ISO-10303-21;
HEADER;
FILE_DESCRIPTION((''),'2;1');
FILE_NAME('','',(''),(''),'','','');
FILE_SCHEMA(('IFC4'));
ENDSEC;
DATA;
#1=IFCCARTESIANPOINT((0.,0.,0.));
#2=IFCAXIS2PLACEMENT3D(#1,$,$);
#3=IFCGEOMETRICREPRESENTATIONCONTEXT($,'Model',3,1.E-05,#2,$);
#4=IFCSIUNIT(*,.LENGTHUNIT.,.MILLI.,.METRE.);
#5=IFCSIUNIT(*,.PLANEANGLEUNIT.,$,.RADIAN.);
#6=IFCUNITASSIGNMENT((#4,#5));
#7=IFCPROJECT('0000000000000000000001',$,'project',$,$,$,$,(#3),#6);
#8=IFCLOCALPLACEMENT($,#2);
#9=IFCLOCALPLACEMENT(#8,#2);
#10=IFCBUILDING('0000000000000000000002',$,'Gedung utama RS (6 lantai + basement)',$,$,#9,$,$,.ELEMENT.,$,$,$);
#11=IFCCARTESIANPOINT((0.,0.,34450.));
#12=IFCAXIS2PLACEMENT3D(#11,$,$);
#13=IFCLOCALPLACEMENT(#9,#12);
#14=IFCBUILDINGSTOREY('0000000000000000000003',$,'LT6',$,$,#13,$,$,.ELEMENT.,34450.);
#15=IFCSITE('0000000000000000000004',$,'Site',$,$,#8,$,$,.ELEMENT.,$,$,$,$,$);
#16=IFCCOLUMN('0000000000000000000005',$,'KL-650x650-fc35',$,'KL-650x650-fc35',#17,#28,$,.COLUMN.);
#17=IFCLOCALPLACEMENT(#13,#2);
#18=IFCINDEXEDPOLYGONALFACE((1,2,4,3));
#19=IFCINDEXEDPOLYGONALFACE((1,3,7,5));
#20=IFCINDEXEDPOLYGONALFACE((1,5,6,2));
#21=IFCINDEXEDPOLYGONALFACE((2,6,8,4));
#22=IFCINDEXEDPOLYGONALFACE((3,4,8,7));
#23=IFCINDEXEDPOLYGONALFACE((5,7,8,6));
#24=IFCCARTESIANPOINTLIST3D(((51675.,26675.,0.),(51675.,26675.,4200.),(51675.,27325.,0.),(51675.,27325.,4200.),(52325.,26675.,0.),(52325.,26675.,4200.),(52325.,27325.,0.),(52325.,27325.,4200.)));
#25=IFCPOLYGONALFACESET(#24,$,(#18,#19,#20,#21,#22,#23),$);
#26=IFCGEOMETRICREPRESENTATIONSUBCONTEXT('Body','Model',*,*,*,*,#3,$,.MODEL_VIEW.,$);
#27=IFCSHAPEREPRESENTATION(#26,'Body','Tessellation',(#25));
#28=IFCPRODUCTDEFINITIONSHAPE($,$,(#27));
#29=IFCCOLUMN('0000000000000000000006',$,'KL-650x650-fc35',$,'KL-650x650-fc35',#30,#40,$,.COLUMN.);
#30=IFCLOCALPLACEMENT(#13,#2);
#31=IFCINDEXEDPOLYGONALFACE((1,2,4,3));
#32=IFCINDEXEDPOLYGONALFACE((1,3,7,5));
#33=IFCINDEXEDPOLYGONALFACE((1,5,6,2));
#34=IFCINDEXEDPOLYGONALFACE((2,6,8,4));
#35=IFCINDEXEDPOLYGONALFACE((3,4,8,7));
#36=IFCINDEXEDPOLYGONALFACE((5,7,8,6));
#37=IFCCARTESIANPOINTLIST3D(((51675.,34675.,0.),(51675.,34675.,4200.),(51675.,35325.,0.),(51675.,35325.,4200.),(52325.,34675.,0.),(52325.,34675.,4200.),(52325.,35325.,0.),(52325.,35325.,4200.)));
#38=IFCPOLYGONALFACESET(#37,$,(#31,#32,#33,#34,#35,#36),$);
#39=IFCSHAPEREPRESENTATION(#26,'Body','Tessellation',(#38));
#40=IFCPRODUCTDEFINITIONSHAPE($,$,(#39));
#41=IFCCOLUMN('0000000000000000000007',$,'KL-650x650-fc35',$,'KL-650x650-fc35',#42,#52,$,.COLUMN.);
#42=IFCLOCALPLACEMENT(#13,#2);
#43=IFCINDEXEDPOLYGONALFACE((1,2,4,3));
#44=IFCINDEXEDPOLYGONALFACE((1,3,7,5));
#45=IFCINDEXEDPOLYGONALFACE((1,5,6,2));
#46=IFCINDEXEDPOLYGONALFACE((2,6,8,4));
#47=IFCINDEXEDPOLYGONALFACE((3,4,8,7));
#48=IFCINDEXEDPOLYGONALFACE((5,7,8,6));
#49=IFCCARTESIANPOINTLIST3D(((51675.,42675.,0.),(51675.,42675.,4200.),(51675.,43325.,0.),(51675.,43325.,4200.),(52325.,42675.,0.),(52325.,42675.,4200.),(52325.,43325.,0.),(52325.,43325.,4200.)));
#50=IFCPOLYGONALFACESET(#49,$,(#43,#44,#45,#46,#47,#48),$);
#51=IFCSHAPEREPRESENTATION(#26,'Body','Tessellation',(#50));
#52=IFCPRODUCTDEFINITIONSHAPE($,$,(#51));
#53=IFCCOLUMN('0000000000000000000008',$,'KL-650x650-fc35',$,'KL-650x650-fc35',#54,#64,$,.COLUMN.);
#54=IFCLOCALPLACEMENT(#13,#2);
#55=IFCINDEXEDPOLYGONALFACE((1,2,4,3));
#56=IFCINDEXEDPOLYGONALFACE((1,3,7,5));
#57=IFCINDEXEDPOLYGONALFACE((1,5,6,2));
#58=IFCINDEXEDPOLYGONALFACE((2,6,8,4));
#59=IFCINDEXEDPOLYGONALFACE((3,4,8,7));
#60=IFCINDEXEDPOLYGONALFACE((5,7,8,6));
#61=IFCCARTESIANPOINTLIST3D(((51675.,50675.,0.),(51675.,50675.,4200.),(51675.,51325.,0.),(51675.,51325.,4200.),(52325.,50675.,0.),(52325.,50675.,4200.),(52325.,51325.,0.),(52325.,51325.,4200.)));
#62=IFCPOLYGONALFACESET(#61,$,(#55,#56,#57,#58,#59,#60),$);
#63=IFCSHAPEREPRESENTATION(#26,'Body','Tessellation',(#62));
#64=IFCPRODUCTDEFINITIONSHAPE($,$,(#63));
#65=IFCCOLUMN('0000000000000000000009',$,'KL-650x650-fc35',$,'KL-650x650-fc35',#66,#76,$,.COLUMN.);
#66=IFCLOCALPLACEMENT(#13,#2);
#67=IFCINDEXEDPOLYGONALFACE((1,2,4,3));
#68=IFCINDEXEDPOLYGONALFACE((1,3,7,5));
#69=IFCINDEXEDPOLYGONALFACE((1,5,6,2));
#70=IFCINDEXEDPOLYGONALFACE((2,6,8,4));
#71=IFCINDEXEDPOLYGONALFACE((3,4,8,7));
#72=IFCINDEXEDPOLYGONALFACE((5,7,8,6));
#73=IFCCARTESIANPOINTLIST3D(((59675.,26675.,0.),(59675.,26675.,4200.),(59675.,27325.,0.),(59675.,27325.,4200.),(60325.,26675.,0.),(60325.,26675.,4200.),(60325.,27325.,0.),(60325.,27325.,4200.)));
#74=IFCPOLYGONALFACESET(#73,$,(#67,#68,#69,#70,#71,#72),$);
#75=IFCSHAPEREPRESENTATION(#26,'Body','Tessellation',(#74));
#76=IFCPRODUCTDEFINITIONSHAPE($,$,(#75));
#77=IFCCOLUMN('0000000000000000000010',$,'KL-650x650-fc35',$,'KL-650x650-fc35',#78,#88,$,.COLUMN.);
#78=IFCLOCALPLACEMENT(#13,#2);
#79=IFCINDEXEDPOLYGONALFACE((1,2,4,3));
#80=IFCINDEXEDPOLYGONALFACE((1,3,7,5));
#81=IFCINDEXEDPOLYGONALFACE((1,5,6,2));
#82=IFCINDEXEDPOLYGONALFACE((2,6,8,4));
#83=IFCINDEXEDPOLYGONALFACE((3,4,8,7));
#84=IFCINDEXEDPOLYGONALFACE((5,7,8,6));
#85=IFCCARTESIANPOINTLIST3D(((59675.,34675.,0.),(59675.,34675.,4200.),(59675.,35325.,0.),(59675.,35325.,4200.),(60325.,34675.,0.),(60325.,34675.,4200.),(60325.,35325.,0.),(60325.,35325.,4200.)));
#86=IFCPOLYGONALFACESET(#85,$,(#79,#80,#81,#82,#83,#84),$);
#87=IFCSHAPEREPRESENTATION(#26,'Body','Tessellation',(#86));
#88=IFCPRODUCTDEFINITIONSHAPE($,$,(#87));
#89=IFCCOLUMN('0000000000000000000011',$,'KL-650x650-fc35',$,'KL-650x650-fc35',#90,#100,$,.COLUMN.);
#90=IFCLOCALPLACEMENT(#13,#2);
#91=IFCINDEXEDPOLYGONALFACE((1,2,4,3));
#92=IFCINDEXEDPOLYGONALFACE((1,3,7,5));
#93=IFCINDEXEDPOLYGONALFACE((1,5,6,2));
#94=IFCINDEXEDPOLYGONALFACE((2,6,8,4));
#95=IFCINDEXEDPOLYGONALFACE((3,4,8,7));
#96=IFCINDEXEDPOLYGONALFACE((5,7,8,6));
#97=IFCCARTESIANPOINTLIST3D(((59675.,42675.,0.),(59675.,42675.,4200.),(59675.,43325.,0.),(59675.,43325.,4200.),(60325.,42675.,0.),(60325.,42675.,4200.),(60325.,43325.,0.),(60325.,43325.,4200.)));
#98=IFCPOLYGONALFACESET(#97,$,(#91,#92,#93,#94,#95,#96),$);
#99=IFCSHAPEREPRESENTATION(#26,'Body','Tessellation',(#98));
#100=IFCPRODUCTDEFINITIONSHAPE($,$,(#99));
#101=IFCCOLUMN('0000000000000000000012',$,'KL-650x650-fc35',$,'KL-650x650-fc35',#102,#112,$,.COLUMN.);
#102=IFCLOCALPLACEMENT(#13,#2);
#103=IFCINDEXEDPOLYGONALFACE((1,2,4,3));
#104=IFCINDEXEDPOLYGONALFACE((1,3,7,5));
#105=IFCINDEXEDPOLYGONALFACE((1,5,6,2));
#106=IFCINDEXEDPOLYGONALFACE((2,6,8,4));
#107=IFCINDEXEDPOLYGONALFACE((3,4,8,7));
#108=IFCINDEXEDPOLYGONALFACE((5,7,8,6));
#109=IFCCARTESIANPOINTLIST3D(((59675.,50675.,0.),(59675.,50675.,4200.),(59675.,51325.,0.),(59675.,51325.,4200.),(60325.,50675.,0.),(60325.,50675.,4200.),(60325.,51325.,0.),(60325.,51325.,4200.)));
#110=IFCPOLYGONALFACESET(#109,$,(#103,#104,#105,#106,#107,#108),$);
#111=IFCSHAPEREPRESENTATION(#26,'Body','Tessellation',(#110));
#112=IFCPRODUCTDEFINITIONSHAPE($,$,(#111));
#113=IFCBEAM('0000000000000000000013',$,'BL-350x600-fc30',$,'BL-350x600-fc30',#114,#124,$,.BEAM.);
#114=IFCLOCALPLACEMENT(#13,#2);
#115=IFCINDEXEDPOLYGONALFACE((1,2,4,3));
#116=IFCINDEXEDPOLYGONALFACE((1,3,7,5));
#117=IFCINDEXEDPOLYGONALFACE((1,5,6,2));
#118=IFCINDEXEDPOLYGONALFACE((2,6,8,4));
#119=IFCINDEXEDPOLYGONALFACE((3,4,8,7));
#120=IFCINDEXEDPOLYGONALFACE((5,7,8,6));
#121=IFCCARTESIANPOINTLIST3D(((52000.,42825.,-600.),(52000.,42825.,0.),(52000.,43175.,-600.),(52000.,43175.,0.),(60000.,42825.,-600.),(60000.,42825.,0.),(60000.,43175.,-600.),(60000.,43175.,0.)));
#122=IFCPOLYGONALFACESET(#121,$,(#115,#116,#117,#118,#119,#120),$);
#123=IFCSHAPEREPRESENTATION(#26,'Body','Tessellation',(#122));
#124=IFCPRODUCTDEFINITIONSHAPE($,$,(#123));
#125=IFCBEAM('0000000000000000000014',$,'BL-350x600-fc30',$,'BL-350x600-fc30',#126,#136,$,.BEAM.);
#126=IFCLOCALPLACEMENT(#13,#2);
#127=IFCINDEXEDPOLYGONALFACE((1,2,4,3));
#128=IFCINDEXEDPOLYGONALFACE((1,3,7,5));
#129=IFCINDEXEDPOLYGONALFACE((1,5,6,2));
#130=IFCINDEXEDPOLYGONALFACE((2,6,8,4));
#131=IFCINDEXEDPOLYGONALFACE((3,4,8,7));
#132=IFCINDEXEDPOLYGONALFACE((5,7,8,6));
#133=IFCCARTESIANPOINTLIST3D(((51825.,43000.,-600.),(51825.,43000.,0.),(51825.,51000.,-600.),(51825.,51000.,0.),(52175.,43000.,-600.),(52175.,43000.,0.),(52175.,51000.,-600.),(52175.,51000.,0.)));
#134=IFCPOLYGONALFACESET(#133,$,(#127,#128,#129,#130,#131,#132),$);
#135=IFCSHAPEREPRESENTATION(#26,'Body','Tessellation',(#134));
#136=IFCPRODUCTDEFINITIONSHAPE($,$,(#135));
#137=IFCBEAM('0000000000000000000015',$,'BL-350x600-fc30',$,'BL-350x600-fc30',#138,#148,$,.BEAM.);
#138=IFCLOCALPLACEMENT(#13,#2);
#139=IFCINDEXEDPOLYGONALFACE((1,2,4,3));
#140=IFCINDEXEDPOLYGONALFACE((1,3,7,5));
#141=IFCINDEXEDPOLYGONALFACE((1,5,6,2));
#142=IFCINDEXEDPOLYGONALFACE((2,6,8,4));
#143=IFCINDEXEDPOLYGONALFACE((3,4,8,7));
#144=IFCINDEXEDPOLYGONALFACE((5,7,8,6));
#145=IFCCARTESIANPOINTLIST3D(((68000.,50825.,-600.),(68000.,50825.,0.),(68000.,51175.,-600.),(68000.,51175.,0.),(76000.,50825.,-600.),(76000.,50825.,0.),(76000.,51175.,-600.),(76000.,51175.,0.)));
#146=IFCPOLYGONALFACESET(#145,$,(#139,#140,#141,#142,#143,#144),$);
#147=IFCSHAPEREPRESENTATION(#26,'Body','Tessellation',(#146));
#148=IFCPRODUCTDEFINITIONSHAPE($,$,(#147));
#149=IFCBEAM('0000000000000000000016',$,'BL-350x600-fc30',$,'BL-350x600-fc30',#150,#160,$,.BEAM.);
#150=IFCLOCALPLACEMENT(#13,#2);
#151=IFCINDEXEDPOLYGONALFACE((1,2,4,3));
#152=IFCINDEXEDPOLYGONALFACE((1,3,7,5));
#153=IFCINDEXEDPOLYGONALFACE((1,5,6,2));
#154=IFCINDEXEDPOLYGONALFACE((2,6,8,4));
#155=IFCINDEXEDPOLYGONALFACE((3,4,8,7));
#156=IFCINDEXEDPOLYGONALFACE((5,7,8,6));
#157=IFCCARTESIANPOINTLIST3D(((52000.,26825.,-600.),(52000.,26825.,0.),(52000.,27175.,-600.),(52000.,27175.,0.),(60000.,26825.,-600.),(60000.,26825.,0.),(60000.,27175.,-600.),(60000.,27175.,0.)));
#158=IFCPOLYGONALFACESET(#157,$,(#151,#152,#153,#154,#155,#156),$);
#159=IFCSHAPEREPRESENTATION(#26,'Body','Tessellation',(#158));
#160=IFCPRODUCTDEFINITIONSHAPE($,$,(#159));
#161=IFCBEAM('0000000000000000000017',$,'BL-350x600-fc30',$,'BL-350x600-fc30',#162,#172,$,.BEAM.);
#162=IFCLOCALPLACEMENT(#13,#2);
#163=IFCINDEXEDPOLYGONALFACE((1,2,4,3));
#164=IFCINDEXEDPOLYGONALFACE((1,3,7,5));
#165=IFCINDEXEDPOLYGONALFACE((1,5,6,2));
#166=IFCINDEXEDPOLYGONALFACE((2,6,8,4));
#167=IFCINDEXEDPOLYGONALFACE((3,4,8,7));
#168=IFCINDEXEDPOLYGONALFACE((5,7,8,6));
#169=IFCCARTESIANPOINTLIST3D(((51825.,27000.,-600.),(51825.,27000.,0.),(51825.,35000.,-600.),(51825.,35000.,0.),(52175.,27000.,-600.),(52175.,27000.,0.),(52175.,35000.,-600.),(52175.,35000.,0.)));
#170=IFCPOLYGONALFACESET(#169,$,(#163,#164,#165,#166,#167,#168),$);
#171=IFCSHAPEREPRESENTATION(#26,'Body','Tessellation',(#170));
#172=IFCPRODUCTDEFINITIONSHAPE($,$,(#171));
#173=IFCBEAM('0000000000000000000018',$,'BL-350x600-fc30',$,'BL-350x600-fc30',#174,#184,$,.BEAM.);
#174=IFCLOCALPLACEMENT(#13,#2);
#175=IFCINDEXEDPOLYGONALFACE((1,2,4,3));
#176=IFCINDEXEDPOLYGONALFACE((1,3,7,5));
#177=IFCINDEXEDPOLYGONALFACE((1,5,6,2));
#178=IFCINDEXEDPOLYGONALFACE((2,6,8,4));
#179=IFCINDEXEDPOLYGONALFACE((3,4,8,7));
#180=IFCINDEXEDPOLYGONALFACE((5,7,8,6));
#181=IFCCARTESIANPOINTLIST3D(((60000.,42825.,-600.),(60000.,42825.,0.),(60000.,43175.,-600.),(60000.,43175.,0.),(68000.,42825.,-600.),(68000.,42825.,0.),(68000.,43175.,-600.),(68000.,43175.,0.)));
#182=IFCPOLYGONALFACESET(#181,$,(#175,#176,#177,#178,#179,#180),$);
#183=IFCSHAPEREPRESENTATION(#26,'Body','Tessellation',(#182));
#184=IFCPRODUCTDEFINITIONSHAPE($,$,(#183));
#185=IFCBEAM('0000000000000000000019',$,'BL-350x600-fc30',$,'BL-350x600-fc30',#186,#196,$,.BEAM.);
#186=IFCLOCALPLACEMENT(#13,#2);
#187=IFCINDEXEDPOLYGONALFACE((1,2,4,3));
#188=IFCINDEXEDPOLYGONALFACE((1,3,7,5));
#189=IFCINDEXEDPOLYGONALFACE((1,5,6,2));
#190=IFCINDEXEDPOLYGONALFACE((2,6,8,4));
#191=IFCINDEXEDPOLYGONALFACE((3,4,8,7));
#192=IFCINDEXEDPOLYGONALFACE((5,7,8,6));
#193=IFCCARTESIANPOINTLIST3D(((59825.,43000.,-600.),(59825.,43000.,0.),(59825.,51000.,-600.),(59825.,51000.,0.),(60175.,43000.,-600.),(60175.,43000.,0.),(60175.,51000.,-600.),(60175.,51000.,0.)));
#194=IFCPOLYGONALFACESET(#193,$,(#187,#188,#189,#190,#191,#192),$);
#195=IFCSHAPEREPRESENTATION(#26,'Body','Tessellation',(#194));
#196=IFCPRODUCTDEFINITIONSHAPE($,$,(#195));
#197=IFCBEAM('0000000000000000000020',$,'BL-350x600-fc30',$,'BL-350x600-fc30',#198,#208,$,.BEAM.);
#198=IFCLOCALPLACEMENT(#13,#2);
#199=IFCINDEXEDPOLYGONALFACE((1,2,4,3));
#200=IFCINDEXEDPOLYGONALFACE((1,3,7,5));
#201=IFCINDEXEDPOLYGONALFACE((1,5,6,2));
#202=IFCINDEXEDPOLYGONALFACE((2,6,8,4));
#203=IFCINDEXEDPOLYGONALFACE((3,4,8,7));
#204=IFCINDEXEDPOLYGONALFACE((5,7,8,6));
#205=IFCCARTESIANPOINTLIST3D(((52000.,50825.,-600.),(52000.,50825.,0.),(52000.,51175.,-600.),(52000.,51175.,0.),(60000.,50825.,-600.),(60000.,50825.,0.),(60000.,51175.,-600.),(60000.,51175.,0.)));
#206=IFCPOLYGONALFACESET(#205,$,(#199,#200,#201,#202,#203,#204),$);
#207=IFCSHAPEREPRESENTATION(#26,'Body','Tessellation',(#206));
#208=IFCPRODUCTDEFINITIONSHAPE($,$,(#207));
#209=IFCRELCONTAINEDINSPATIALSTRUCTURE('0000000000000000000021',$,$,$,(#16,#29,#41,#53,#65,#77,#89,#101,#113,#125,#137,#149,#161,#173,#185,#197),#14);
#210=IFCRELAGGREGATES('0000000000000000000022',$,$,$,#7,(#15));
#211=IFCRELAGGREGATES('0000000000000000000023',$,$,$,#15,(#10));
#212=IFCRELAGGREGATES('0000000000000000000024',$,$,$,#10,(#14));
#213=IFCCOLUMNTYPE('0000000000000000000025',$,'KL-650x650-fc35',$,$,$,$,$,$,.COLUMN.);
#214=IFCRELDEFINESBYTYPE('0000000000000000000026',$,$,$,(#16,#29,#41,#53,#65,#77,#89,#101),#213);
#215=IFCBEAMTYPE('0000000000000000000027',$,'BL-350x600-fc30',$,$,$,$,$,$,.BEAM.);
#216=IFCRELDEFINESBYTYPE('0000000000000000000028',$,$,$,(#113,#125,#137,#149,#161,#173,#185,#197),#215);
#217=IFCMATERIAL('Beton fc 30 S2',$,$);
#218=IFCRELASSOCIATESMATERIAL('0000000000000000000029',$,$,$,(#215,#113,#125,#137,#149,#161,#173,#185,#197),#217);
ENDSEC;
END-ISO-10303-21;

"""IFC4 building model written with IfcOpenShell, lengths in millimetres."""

from ifc_helpers import new_model, si_unit, frame, origin, origin_2d, place, context, subcontext, project, spatial, rectangle, extrude, material, material_profile, profile_set, profile_usage, type_object, element, save


model = new_model("IFC4")

# Units and contexts
model_context = context("Model", 3, precision=1e-05, world=origin())
body_context = subcontext(model_context, "Body", "Model", "MODEL_VIEW")
ifc_project = project(units=[si_unit("LENGTHUNIT", "METRE", prefix="MILLI"), si_unit("PLANEANGLEUNIT", "RADIAN")], contexts=[model_context])

# Site, building, storey
site_placement = place(None, origin())
site = spatial("IfcSite", under=ifc_project, at=site_placement, Name="Site", CompositionType="ELEMENT")
building_placement = place(site_placement, origin())
building = spatial("IfcBuilding", under=site, at=building_placement, Name="Gedung utama RS (6 lantai + basement)", CompositionType="ELEMENT")
storey_placement = place(building_placement, frame((0.0, 0.0, 34450.0)))
storey = spatial("IfcBuildingStorey", under=building, at=storey_placement, Name="LT6", CompositionType="ELEMENT", Elevation=34450.0)

# Columns
ifc_material_profile_1 = material_profile(None, rectangle(XDim=650.0, YDim=650.0, at=origin_2d()), Name="KL-650x650-fc35")
ifc_profile_set_1 = profile_set([ifc_material_profile_1], Name="KL-650x650-fc35")
ifc_profile_usage_1 = profile_usage(ifc_profile_set_1, cardinal=5)
column_type = type_object("IfcColumnType", Name="KL-650x650-fc35", PredefinedType="COLUMN", material=ifc_profile_set_1)
for number, where, z_axis, x_axis, name in (
    (1, (52000.0, 27000.0, 0.0), (0.0, 0.0, 1.0), (1.0, 0.0, 0.0), "KL-650x650-fc35"),
    (2, (52000.0, 35000.0, 0.0), (0.0, 0.0, 1.0), (1.0, 0.0, 0.0), "KL-650x650-fc35"),
    (3, (52000.0, 43000.0, 0.0), (0.0, 0.0, 1.0), (1.0, 0.0, 0.0), "KL-650x650-fc35"),
    (4, (52000.0, 51000.0, 0.0), (0.0, 0.0, 1.0), (1.0, 0.0, 0.0), "KL-650x650-fc35"),
    (5, (60000.0, 27000.0, 0.0), (0.0, 0.0, 1.0), (1.0, 0.0, 0.0), "KL-650x650-fc35"),
    (6, (60000.0, 35000.0, 0.0), (0.0, 0.0, 1.0), (1.0, 0.0, 0.0), "KL-650x650-fc35"),
    (7, (60000.0, 43000.0, 0.0), (0.0, 0.0, 1.0), (1.0, 0.0, 0.0), "KL-650x650-fc35"),
    (8, (60000.0, 51000.0, 0.0), (0.0, 0.0, 1.0), (1.0, 0.0, 0.0), "KL-650x650-fc35"),
):
    element("IfcColumn", number, at=place(storey_placement, frame(where, z_axis=z_axis, x_axis=x_axis)), inside=storey, type_object=column_type, material=ifc_profile_usage_1, Name=name, ObjectType="KL-650x650-fc35", PredefinedType="COLUMN", context=body_context, shape_type="SweptSolid", body=[
        extrude(rectangle(XDim=650.0, YDim=650.0, at=origin_2d()), origin(), (0.0, 0.0, 1.0), 4200.0),
    ])

# Beams
ifc_material_1 = material(Name="Beton fc 30 S2")
ifc_material_profile_2 = material_profile(ifc_material_1, rectangle(XDim=350.0, YDim=600.0, at=origin_2d()), Name="BL-350x600-fc30")
ifc_profile_set_2 = profile_set([ifc_material_profile_2], Name="BL-350x600-fc30")
ifc_profile_usage_2 = profile_usage(ifc_profile_set_2, cardinal=8)
beam_type = type_object("IfcBeamType", Name="BL-350x600-fc30", PredefinedType="BEAM", material=ifc_profile_set_2)
beam_1_placement = place(storey_placement, frame((52000.0, 43000.0, -300.0)))
element("IfcBeam", 9, at=beam_1_placement, inside=storey, type_object=beam_type, material=ifc_profile_usage_2, Name="BL-350x600-fc30", ObjectType="BL-350x600-fc30", PredefinedType="BEAM", context=body_context, shape_type="SweptSolid", body=[
    extrude(rectangle(XDim=350.0, YDim=600.0, at=origin_2d()), frame((0.0, 0.0, 0.0), z_axis=(1.0, 0.0, 0.0), x_axis=(0.0, 1.0, 0.0)), (0.0, 0.0, 1.0), 8000.0),
])
beam_2_placement = place(storey_placement, frame((52000.0, 43000.0, -300.0)))
element("IfcBeam", 10, at=beam_2_placement, inside=storey, type_object=beam_type, material=ifc_profile_usage_2, Name="BL-350x600-fc30", ObjectType="BL-350x600-fc30", PredefinedType="BEAM", context=body_context, shape_type="SweptSolid", body=[
    extrude(rectangle(XDim=350.0, YDim=600.0, at=origin_2d()), frame((0.0, 0.0, 0.0), z_axis=(0.0, 1.0, 0.0), x_axis=(-1.0, 0.0, 0.0)), (0.0, 0.0, 1.0), 8000.0),
])
for number, where, name in (
    (11, (68000.0, 51000.0, -300.0), "BL-350x600-fc30"),
    (12, (52000.0, 27000.0, -300.0), "BL-350x600-fc30"),
):
    element("IfcBeam", number, at=place(storey_placement, frame(where)), inside=storey, type_object=beam_type, material=ifc_profile_usage_2, Name=name, ObjectType="BL-350x600-fc30", PredefinedType="BEAM", context=body_context, shape_type="SweptSolid", body=[
        extrude(rectangle(XDim=350.0, YDim=600.0, at=origin_2d()), frame((0.0, 0.0, 0.0), z_axis=(1.0, 0.0, 0.0), x_axis=(0.0, 1.0, 0.0)), (0.0, 0.0, 1.0), 8000.0),
    ])
beam_3_placement = place(storey_placement, frame((52000.0, 27000.0, -300.0)))
element("IfcBeam", 13, at=beam_3_placement, inside=storey, type_object=beam_type, material=ifc_profile_usage_2, Name="BL-350x600-fc30", ObjectType="BL-350x600-fc30", PredefinedType="BEAM", context=body_context, shape_type="SweptSolid", body=[
    extrude(rectangle(XDim=350.0, YDim=600.0, at=origin_2d()), frame((0.0, 0.0, 0.0), z_axis=(0.0, 1.0, 0.0), x_axis=(-1.0, 0.0, 0.0)), (0.0, 0.0, 1.0), 8000.0),
])
beam_4_placement = place(storey_placement, frame((60000.0, 43000.0, -300.0)))
element("IfcBeam", 14, at=beam_4_placement, inside=storey, type_object=beam_type, material=ifc_profile_usage_2, Name="BL-350x600-fc30", ObjectType="BL-350x600-fc30", PredefinedType="BEAM", context=body_context, shape_type="SweptSolid", body=[
    extrude(rectangle(XDim=350.0, YDim=600.0, at=origin_2d()), frame((0.0, 0.0, 0.0), z_axis=(1.0, 0.0, 0.0), x_axis=(0.0, 1.0, 0.0)), (0.0, 0.0, 1.0), 8000.0),
])
beam_5_placement = place(storey_placement, frame((60000.0, 43000.0, -300.0)))
element("IfcBeam", 15, at=beam_5_placement, inside=storey, type_object=beam_type, material=ifc_profile_usage_2, Name="BL-350x600-fc30", ObjectType="BL-350x600-fc30", PredefinedType="BEAM", context=body_context, shape_type="SweptSolid", body=[
    extrude(rectangle(XDim=350.0, YDim=600.0, at=origin_2d()), frame((0.0, 0.0, 0.0), z_axis=(0.0, 1.0, 0.0), x_axis=(-1.0, 0.0, 0.0)), (0.0, 0.0, 1.0), 8000.0),
])
for number, where, name in (
    (16, (52000.0, 51000.0, -300.0), "BL-350x600-fc30"),
):
    element("IfcBeam", number, at=place(storey_placement, frame(where)), inside=storey, type_object=beam_type, material=ifc_profile_usage_2, Name=name, ObjectType="BL-350x600-fc30", PredefinedType="BEAM", context=body_context, shape_type="SweptSolid", body=[
        extrude(rectangle(XDim=350.0, YDim=600.0, at=origin_2d()), frame((0.0, 0.0, 0.0), z_axis=(1.0, 0.0, 0.0), x_axis=(0.0, 1.0, 0.0)), (0.0, 0.0, 1.0), 8000.0),
    ])

save(model, "model.ifc")
